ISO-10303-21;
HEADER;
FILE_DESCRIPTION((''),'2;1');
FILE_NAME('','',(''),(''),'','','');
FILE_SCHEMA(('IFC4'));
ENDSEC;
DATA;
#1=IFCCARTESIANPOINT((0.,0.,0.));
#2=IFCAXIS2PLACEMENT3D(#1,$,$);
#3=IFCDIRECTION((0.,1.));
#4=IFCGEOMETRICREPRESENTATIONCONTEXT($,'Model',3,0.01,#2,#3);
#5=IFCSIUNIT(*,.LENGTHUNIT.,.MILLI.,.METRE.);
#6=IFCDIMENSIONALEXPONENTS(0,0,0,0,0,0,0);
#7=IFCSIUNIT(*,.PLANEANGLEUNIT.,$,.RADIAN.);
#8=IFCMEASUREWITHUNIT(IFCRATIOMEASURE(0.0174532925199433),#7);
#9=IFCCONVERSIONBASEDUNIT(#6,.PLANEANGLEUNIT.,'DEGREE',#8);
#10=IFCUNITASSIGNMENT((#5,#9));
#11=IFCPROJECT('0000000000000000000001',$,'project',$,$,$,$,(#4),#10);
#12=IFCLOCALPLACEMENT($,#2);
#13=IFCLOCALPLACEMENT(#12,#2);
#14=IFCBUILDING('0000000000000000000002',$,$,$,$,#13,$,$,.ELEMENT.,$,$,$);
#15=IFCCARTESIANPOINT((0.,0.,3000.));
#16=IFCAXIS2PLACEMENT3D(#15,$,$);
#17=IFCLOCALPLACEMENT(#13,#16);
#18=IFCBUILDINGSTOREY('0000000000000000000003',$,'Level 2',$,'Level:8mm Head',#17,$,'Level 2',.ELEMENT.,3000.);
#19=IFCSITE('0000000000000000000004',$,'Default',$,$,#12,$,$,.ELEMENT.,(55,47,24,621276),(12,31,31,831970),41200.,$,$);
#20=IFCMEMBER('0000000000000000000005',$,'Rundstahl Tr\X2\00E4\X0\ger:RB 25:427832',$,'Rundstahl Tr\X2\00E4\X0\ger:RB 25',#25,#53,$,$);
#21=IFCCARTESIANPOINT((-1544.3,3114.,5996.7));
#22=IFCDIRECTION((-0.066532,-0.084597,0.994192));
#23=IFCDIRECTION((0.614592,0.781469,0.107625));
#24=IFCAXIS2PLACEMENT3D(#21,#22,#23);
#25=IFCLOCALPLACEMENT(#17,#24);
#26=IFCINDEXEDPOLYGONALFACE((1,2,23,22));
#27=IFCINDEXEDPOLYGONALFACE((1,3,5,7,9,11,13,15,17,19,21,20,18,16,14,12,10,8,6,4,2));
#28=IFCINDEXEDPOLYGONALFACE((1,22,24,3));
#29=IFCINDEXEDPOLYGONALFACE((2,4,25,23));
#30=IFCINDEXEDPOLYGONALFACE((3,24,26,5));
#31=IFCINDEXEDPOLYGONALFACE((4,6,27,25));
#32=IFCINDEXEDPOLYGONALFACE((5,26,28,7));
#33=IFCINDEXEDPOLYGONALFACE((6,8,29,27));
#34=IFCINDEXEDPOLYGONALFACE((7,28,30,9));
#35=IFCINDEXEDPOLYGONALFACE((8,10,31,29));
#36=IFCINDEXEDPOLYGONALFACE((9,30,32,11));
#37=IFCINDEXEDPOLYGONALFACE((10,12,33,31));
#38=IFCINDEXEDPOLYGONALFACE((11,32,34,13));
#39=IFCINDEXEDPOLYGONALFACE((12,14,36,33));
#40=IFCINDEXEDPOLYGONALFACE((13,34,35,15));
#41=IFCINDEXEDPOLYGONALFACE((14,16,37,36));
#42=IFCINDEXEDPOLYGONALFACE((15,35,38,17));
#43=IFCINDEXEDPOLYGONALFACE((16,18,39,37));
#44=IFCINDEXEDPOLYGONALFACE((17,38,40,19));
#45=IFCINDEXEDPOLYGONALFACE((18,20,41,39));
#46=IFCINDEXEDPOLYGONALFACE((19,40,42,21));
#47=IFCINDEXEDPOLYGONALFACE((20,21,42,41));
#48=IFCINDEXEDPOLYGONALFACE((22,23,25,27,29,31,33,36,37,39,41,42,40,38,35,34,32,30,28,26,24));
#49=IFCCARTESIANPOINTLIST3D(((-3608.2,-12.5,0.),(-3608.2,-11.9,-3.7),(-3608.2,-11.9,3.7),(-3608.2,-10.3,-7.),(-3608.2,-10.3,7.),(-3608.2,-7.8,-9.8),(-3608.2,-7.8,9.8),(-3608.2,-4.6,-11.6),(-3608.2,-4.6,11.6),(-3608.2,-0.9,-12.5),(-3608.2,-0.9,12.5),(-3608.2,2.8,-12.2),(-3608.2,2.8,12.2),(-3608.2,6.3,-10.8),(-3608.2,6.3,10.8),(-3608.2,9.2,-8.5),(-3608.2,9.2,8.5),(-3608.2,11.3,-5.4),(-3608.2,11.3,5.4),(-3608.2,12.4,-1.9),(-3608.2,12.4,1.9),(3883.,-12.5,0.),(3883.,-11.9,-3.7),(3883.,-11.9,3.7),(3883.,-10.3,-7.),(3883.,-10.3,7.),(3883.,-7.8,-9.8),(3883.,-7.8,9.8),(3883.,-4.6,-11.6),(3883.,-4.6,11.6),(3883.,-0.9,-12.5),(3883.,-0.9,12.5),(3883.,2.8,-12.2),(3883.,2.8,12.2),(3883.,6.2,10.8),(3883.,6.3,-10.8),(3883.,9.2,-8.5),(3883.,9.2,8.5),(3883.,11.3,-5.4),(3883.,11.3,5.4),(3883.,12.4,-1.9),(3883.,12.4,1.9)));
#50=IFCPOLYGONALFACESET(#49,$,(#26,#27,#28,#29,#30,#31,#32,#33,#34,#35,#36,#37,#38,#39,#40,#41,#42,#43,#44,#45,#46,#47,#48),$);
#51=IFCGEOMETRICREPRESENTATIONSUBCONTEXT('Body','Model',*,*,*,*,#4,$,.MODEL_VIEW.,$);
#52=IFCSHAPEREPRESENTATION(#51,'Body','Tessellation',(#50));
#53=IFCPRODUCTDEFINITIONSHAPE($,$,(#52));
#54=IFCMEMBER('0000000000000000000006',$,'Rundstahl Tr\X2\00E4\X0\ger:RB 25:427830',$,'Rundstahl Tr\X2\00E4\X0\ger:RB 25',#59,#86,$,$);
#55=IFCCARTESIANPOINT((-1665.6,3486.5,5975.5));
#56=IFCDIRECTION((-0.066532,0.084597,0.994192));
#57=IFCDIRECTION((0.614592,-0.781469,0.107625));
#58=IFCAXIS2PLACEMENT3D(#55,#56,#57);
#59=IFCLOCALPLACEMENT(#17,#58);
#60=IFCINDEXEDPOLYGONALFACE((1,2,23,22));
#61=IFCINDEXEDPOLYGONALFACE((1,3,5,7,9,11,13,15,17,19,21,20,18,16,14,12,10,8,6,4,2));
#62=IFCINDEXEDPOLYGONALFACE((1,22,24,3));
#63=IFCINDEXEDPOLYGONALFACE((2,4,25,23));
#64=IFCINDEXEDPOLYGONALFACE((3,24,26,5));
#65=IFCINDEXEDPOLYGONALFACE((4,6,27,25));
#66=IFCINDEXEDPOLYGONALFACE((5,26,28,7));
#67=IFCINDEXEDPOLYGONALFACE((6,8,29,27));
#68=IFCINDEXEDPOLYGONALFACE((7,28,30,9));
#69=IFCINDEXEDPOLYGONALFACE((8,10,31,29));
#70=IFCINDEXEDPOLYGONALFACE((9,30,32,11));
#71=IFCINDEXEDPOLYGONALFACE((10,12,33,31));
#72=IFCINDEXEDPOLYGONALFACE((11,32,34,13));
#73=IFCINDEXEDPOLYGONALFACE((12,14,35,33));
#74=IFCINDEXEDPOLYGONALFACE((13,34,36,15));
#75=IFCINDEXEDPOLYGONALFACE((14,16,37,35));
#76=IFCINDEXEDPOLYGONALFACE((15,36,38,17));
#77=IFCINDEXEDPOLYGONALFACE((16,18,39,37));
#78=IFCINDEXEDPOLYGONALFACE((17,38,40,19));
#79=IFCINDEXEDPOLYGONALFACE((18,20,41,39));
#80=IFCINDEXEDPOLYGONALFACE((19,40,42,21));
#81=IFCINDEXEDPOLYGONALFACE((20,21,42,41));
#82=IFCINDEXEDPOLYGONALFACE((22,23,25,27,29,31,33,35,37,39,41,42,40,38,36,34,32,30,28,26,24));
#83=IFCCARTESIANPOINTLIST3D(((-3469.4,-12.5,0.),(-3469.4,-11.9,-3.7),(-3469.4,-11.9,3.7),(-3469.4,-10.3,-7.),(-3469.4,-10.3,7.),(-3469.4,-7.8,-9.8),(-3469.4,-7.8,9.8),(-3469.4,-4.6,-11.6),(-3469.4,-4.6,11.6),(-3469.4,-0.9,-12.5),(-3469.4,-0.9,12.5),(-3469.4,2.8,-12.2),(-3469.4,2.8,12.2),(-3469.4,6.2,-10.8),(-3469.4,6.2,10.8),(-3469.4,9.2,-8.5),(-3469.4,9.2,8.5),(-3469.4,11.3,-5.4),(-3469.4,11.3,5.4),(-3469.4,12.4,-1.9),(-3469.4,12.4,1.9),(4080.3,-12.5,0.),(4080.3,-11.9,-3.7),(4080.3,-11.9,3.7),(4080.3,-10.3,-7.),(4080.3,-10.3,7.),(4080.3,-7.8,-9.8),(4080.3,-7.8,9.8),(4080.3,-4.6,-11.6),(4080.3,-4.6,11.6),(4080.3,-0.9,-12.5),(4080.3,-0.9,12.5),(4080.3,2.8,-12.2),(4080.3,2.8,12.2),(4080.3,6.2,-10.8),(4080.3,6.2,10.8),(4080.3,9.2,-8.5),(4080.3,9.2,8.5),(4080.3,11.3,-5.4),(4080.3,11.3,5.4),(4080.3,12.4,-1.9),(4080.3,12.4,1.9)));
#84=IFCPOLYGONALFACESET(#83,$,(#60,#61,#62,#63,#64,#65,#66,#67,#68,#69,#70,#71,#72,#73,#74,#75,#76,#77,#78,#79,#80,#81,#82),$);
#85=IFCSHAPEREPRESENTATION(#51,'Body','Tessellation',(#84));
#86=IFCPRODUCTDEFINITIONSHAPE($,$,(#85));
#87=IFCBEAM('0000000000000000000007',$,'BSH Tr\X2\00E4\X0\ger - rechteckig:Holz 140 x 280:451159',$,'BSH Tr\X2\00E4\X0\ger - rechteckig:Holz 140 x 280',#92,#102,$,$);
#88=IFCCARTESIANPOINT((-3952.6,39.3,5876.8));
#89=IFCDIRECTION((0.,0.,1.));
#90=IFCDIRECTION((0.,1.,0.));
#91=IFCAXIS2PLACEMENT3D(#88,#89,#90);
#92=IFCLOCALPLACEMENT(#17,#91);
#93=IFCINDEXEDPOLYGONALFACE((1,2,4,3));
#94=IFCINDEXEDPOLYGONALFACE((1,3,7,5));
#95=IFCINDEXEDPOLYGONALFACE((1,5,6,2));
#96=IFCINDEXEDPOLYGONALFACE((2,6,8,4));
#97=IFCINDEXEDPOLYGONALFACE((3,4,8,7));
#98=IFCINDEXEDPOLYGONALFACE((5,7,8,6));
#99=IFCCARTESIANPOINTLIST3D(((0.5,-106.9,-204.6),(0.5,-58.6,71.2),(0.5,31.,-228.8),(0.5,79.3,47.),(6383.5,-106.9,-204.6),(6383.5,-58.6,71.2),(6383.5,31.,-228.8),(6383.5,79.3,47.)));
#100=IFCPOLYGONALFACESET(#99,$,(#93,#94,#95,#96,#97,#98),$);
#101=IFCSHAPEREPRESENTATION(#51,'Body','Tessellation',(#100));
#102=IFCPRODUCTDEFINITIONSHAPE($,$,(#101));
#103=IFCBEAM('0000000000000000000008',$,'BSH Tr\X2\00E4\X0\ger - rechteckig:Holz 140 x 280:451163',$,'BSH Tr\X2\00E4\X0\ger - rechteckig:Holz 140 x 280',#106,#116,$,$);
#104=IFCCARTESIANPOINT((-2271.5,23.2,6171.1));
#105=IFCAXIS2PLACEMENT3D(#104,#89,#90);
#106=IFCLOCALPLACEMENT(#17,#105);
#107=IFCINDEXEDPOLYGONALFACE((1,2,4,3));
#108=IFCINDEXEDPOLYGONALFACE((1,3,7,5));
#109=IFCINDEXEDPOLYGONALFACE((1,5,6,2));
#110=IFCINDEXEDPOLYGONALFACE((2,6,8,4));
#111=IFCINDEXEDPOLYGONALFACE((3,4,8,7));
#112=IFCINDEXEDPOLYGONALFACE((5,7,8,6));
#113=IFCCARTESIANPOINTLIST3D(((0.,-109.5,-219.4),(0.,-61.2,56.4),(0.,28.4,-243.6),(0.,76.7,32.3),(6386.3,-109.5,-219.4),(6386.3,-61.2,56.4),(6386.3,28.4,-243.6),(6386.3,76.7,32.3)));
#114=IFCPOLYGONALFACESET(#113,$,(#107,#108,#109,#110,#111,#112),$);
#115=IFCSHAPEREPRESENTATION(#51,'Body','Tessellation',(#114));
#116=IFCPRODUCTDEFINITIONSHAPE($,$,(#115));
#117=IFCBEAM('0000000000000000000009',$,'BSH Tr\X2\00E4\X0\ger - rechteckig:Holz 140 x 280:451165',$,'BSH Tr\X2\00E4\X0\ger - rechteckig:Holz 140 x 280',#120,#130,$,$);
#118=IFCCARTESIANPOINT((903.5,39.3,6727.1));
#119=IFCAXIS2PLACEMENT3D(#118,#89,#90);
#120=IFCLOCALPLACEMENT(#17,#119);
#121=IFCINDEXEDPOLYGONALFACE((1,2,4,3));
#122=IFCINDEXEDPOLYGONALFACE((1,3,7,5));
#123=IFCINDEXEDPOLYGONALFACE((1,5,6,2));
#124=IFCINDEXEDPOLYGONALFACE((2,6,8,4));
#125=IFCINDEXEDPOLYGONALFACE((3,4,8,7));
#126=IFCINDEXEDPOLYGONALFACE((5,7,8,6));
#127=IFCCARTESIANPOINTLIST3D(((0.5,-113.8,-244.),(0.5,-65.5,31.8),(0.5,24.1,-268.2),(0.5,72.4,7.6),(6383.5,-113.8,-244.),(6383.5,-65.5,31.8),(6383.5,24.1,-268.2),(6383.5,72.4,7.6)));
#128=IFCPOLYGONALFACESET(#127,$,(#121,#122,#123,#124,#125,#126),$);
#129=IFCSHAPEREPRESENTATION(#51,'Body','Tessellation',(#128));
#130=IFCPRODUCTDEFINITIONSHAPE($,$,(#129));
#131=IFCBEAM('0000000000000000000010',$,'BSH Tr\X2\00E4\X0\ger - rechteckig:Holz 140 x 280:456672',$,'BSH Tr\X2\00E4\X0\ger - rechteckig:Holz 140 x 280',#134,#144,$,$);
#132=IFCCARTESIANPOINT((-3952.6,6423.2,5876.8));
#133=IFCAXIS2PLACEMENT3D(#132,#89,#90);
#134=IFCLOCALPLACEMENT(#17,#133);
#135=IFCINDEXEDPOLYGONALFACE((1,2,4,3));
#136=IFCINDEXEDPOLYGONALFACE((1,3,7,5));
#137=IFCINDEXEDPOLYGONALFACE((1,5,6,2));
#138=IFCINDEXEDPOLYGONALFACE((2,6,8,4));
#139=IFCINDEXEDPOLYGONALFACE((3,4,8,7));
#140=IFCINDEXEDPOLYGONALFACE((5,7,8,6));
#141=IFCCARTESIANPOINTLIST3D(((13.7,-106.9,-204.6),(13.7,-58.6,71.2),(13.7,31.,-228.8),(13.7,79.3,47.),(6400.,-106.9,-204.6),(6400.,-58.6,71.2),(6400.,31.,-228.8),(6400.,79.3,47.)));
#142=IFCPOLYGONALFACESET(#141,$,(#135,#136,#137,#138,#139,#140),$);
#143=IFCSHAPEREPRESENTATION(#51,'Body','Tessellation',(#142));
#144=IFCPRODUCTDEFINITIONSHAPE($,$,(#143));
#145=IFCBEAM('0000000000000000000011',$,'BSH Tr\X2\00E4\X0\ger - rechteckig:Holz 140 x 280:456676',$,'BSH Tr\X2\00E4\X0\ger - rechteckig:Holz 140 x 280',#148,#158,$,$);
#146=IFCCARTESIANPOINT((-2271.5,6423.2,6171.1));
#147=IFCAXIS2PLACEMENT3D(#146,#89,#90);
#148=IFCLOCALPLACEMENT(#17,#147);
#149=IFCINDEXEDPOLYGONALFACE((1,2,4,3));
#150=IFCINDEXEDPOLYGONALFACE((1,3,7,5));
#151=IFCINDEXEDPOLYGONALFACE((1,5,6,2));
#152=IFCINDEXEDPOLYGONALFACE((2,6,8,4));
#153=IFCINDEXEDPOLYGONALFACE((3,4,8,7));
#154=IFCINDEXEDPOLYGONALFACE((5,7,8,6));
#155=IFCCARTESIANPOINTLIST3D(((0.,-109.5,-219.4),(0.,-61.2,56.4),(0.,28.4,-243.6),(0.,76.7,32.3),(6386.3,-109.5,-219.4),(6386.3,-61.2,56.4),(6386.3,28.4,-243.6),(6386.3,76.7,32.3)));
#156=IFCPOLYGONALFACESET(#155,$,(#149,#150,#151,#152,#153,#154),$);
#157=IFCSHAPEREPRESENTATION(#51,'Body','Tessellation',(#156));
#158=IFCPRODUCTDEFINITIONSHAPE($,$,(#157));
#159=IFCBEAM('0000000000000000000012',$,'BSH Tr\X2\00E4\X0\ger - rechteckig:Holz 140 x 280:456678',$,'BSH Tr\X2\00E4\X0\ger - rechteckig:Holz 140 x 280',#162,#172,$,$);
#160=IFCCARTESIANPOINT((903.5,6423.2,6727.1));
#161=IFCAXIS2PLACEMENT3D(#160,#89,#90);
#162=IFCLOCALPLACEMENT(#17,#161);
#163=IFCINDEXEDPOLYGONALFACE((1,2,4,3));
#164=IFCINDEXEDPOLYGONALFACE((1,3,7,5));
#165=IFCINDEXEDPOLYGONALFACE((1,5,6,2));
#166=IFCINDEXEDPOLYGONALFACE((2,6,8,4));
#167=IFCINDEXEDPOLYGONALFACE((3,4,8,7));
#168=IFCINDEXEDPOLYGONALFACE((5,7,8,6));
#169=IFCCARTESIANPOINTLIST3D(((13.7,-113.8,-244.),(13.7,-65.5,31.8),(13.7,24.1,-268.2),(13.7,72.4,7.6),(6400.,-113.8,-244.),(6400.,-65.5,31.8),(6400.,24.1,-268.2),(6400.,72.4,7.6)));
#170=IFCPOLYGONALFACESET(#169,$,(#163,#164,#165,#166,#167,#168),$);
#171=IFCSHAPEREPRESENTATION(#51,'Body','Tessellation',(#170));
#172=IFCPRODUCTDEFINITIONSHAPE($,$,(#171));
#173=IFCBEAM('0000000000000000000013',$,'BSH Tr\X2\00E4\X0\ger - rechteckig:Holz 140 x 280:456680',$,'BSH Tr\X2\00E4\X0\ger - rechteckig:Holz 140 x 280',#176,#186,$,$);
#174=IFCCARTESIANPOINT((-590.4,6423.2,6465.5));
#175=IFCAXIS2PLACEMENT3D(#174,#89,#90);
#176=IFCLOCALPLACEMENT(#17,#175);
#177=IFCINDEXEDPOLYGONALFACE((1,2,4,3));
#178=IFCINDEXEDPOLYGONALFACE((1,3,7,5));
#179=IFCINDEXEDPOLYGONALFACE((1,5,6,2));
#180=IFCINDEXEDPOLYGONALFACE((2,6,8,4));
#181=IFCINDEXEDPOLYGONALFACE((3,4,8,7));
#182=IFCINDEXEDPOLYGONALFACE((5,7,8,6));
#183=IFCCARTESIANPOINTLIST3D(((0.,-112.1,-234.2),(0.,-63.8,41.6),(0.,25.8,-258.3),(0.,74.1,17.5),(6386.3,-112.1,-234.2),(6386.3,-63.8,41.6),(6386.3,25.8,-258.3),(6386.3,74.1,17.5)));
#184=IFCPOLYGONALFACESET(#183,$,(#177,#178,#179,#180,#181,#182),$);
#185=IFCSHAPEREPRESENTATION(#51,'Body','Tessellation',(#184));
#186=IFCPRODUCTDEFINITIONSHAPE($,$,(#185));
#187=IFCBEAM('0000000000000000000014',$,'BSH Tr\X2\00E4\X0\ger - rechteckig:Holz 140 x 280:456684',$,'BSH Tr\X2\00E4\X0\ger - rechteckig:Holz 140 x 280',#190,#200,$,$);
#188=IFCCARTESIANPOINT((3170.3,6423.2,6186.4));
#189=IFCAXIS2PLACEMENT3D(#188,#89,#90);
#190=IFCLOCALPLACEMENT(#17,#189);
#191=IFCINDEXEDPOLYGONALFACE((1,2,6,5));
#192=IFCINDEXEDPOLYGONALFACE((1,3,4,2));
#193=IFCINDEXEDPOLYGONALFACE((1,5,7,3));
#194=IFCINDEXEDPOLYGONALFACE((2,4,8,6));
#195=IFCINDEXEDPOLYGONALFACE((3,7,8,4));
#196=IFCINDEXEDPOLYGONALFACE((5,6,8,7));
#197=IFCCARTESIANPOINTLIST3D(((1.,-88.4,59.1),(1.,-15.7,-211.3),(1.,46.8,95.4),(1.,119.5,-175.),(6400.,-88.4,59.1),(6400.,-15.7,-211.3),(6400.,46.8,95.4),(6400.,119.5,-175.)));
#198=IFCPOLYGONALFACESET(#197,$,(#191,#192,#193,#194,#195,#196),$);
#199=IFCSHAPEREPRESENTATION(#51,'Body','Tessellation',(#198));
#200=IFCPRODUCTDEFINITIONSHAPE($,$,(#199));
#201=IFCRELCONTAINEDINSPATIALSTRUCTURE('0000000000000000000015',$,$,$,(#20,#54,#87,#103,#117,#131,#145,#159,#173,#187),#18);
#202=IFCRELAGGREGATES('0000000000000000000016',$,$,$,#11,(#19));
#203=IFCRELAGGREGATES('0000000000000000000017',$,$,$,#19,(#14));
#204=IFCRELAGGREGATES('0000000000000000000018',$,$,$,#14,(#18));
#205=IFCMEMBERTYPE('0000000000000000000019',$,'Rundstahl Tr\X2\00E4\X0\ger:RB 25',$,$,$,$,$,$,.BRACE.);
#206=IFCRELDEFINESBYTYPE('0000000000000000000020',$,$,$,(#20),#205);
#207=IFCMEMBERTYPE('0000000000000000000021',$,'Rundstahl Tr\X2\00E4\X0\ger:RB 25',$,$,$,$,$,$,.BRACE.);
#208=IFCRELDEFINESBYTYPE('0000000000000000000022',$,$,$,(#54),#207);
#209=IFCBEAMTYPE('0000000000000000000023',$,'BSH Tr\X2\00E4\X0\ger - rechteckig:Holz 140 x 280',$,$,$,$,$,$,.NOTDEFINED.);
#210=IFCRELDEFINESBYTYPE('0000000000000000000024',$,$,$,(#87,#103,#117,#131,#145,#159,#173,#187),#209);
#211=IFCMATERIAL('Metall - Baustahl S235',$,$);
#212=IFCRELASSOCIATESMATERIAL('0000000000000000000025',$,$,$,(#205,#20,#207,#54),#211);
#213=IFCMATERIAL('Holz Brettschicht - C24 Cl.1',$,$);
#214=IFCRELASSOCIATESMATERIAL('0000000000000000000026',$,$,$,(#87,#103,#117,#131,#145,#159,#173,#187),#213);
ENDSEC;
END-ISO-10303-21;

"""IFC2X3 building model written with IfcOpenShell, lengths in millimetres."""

from ifc_helpers import new_model, entity, si_unit, converted_unit, direction, frame, frame_2d, origin, origin_2d_with_axis, place, context, subcontext, project, spatial, rectangle, circle, extrude, source, transform, mapped, material, type_object, type_shapes, element, save


model = new_model("IFC2X3")

# Units and contexts
model_context = context("Model", 3, precision=0.01, world=origin(), true_north=direction((0.0, 1.0)))
body_context = subcontext(model_context, "Body", "Model", "MODEL_VIEW")
ifc_project = project(units=[si_unit("LENGTHUNIT", "METRE", prefix="MILLI"), converted_unit("PLANEANGLEUNIT", "DEGREE", entity("IfcRatioMeasure", 0.0174532925199433), si_unit("PLANEANGLEUNIT", "RADIAN"), dimensions=[0, 0, 0, 0, 0, 0, 0])], contexts=[model_context])

# Site, building, storey
site_placement = place(None, origin())
site = spatial("IfcSite", under=ifc_project, at=site_placement, Name="Default", CompositionType="ELEMENT", RefLatitude=(55, 47, 24, 621276), RefLongitude=(12, 31, 31, 831970), RefElevation=41200.0)
building_placement = place(site_placement, origin())
building = spatial("IfcBuilding", under=site, at=building_placement, CompositionType="ELEMENT")
storey_placement = place(building_placement, frame((0.0, 0.0, 3000.0)))
storey = spatial("IfcBuildingStorey", under=building, at=storey_placement, Name="Level 2", ObjectType="Level:8mm Head", LongName="Level 2", CompositionType="ELEMENT", Elevation=3000.0)

# Shared definitions
ifc_material_1 = material(Name="Holz Brettschicht - C24 Cl.1")
ifc_material_2 = material(Name="Metall - Baustahl S235")

# Members
member_type_1 = type_object("IfcMemberType", Name="Rundstahl Träger:RB 25", PredefinedType="BRACE", material=ifc_material_2)
shared_shape_1 = source(origin(), body_context, "Body", "SweptSolid", [
    extrude(circle(Radius=12.5, at=frame_2d((0.0, 0.0), x_axis=(1.0, 0.0))), frame((-3608.2, 0.0, 0.0), z_axis=(1.0, 0.0, 0.0), x_axis=(0.0, -1.0, 0.0)), (0.0, 0.0, 1.0), 7491.1),
])
type_shapes(member_type_1, [shared_shape_1])
member_1_placement = place(storey_placement, frame((-1544.3, 3114.0, 5996.7), z_axis=(-0.066532, -0.084597, 0.994192), x_axis=(0.614592, 0.781469, 0.107625)))
element("IfcMember", 1, at=member_1_placement, inside=storey, type_object=member_type_1, material=ifc_material_2, Name="Rundstahl Träger:RB 25:427832", ObjectType="Rundstahl Träger:RB 25", context=body_context, shape_type="MappedRepresentation", body=[
    mapped(shared_shape_1, transform((0.0, 0.0, 0.0), scale=1.0)),
])
member_type_2 = type_object("IfcMemberType", Name="Rundstahl Träger:RB 25", PredefinedType="BRACE", material=ifc_material_2)
shared_shape_2 = source(origin(), body_context, "Body", "SweptSolid", [
    extrude(circle(Radius=12.5, at=frame_2d((0.0, 0.0), x_axis=(1.0, 0.0))), frame((-3469.4, 0.0, 0.0), z_axis=(1.0, 0.0, 0.0), x_axis=(0.0, -1.0, 0.0)), (0.0, 0.0, 1.0), 7549.6),
])
type_shapes(member_type_2, [shared_shape_2])
member_2_placement = place(storey_placement, frame((-1665.6, 3486.5, 5975.5), z_axis=(-0.066532, 0.084597, 0.994192), x_axis=(0.614592, -0.781469, 0.107625)))
element("IfcMember", 2, at=member_2_placement, inside=storey, type_object=member_type_2, material=ifc_material_2, Name="Rundstahl Träger:RB 25:427830", ObjectType="Rundstahl Träger:RB 25", context=body_context, shape_type="MappedRepresentation", body=[
    mapped(shared_shape_2, transform((0.0, 0.0, 0.0), scale=1.0)),
])

# Beams
beam_type_1 = type_object("IfcBeamType", Name="BSH Träger - rechteckig:Holz 140 x 280", PredefinedType="NOTDEFINED")
beam_1_placement = place(storey_placement, frame((-3952.6, 39.3, 5876.8), z_axis=(0.0, 0.0, 1.0), x_axis=(0.0, 1.0, 0.0)))
element("IfcBeam", 3, at=beam_1_placement, inside=storey, type_object=beam_type_1, material=ifc_material_1, Name="BSH Träger - rechteckig:Holz 140 x 280:451159", ObjectType="BSH Träger - rechteckig:Holz 140 x 280", context=body_context, shape_type="SweptSolid", body=[
    extrude(rectangle(XDim=280.0, YDim=140.0, at=origin_2d_with_axis()), frame((0.5, -13.8, -78.8), z_axis=(1.0, 0.0, 0.0), x_axis=(0.0, 0.172491, 0.985011)), (0.0, 0.0, 1.0), 6383.0),
])
beam_2_placement = place(storey_placement, frame((-2271.5, 23.2, 6171.1), z_axis=(0.0, 0.0, 1.0), x_axis=(0.0, 1.0, 0.0)))
element("IfcBeam", 4, at=beam_2_placement, inside=storey, type_object=beam_type_1, material=ifc_material_1, Name="BSH Träger - rechteckig:Holz 140 x 280:451163", ObjectType="BSH Träger - rechteckig:Holz 140 x 280", context=body_context, shape_type="SweptSolid", body=[
    extrude(rectangle(XDim=280.0, YDim=140.0, at=frame_2d((0.0, 0.0), x_axis=(1.0, 0.0))), frame((0.0, -16.4, -93.6), z_axis=(1.0, 0.0, 0.0), x_axis=(0.0, 0.172491, 0.985011)), (0.0, 0.0, 1.0), 6386.3),
])
beam_3_placement = place(storey_placement, frame((903.5, 39.3, 6727.1), z_axis=(0.0, 0.0, 1.0), x_axis=(0.0, 1.0, 0.0)))
element("IfcBeam", 5, at=beam_3_placement, inside=storey, type_object=beam_type_1, material=ifc_material_1, Name="BSH Träger - rechteckig:Holz 140 x 280:451165", ObjectType="BSH Träger - rechteckig:Holz 140 x 280", context=body_context, shape_type="SweptSolid", body=[
    extrude(rectangle(XDim=280.0, YDim=140.0, at=frame_2d((0.0, 0.0), x_axis=(1.0, 0.0))), frame((0.5, -20.7, -118.2), z_axis=(1.0, 0.0, 0.0), x_axis=(0.0, 0.172491, 0.985011)), (0.0, 0.0, 1.0), 6383.0),
])
beam_4_placement = place(storey_placement, frame((-3952.6, 6423.2, 5876.8), z_axis=(0.0, 0.0, 1.0), x_axis=(0.0, 1.0, 0.0)))
element("IfcBeam", 6, at=beam_4_placement, inside=storey, type_object=beam_type_1, material=ifc_material_1, Name="BSH Träger - rechteckig:Holz 140 x 280:456672", ObjectType="BSH Träger - rechteckig:Holz 140 x 280", context=body_context, shape_type="SweptSolid", body=[
    extrude(rectangle(XDim=280.0, YDim=140.0, at=origin_2d_with_axis()), frame((13.7, -13.8, -78.8), z_axis=(1.0, 0.0, 0.0), x_axis=(0.0, 0.172491, 0.985011)), (0.0, 0.0, 1.0), 6386.3),
])
beam_5_placement = place(storey_placement, frame((-2271.5, 6423.2, 6171.1), z_axis=(0.0, 0.0, 1.0), x_axis=(0.0, 1.0, 0.0)))
element("IfcBeam", 7, at=beam_5_placement, inside=storey, type_object=beam_type_1, material=ifc_material_1, Name="BSH Träger - rechteckig:Holz 140 x 280:456676", ObjectType="BSH Träger - rechteckig:Holz 140 x 280", context=body_context, shape_type="SweptSolid", body=[
    extrude(rectangle(XDim=280.0, YDim=140.0, at=frame_2d((0.0, 0.0), x_axis=(1.0, 0.0))), frame((0.0, -16.4, -93.6), z_axis=(1.0, 0.0, 0.0), x_axis=(0.0, 0.172491, 0.985011)), (0.0, 0.0, 1.0), 6386.3),
])
beam_6_placement = place(storey_placement, frame((903.5, 6423.2, 6727.1), z_axis=(0.0, 0.0, 1.0), x_axis=(0.0, 1.0, 0.0)))
element("IfcBeam", 8, at=beam_6_placement, inside=storey, type_object=beam_type_1, material=ifc_material_1, Name="BSH Träger - rechteckig:Holz 140 x 280:456678", ObjectType="BSH Träger - rechteckig:Holz 140 x 280", context=body_context, shape_type="SweptSolid", body=[
    extrude(rectangle(XDim=280.0, YDim=140.0, at=frame_2d((0.0, 0.0), x_axis=(1.0, 0.0))), frame((13.7, -20.7, -118.2), z_axis=(1.0, 0.0, 0.0), x_axis=(0.0, 0.172491, 0.985011)), (0.0, 0.0, 1.0), 6386.3),
])
beam_7_placement = place(storey_placement, frame((-590.4, 6423.2, 6465.5), z_axis=(0.0, 0.0, 1.0), x_axis=(0.0, 1.0, 0.0)))
element("IfcBeam", 9, at=beam_7_placement, inside=storey, type_object=beam_type_1, material=ifc_material_1, Name="BSH Träger - rechteckig:Holz 140 x 280:456680", ObjectType="BSH Träger - rechteckig:Holz 140 x 280", context=body_context, shape_type="SweptSolid", body=[
    extrude(rectangle(XDim=280.0, YDim=140.0, at=frame_2d((0.0, 0.0), x_axis=(1.0, 0.0))), frame((0.0, -19.0, -108.4), z_axis=(1.0, 0.0, 0.0), x_axis=(0.0, 0.172491, 0.985011)), (0.0, 0.0, 1.0), 6386.3),
])
beam_8_placement = place(storey_placement, frame((3170.3, 6423.2, 6186.4), z_axis=(0.0, 0.0, 1.0), x_axis=(0.0, 1.0, 0.0)))
element("IfcBeam", 10, at=beam_8_placement, inside=storey, type_object=beam_type_1, material=ifc_material_1, Name="BSH Träger - rechteckig:Holz 140 x 280:456684", ObjectType="BSH Träger - rechteckig:Holz 140 x 280", context=body_context, shape_type="SweptSolid", body=[
    extrude(rectangle(XDim=280.0, YDim=140.0, at=frame_2d((0.0, 0.0), x_axis=(1.0, 0.0))), frame((1.0, 15.6, -57.9), z_axis=(1.0, 0.0, 0.0), x_axis=(0.0, -0.259528, 0.965735)), (0.0, 0.0, 1.0), 6399.0),
])

save(model, "model.ifc")
